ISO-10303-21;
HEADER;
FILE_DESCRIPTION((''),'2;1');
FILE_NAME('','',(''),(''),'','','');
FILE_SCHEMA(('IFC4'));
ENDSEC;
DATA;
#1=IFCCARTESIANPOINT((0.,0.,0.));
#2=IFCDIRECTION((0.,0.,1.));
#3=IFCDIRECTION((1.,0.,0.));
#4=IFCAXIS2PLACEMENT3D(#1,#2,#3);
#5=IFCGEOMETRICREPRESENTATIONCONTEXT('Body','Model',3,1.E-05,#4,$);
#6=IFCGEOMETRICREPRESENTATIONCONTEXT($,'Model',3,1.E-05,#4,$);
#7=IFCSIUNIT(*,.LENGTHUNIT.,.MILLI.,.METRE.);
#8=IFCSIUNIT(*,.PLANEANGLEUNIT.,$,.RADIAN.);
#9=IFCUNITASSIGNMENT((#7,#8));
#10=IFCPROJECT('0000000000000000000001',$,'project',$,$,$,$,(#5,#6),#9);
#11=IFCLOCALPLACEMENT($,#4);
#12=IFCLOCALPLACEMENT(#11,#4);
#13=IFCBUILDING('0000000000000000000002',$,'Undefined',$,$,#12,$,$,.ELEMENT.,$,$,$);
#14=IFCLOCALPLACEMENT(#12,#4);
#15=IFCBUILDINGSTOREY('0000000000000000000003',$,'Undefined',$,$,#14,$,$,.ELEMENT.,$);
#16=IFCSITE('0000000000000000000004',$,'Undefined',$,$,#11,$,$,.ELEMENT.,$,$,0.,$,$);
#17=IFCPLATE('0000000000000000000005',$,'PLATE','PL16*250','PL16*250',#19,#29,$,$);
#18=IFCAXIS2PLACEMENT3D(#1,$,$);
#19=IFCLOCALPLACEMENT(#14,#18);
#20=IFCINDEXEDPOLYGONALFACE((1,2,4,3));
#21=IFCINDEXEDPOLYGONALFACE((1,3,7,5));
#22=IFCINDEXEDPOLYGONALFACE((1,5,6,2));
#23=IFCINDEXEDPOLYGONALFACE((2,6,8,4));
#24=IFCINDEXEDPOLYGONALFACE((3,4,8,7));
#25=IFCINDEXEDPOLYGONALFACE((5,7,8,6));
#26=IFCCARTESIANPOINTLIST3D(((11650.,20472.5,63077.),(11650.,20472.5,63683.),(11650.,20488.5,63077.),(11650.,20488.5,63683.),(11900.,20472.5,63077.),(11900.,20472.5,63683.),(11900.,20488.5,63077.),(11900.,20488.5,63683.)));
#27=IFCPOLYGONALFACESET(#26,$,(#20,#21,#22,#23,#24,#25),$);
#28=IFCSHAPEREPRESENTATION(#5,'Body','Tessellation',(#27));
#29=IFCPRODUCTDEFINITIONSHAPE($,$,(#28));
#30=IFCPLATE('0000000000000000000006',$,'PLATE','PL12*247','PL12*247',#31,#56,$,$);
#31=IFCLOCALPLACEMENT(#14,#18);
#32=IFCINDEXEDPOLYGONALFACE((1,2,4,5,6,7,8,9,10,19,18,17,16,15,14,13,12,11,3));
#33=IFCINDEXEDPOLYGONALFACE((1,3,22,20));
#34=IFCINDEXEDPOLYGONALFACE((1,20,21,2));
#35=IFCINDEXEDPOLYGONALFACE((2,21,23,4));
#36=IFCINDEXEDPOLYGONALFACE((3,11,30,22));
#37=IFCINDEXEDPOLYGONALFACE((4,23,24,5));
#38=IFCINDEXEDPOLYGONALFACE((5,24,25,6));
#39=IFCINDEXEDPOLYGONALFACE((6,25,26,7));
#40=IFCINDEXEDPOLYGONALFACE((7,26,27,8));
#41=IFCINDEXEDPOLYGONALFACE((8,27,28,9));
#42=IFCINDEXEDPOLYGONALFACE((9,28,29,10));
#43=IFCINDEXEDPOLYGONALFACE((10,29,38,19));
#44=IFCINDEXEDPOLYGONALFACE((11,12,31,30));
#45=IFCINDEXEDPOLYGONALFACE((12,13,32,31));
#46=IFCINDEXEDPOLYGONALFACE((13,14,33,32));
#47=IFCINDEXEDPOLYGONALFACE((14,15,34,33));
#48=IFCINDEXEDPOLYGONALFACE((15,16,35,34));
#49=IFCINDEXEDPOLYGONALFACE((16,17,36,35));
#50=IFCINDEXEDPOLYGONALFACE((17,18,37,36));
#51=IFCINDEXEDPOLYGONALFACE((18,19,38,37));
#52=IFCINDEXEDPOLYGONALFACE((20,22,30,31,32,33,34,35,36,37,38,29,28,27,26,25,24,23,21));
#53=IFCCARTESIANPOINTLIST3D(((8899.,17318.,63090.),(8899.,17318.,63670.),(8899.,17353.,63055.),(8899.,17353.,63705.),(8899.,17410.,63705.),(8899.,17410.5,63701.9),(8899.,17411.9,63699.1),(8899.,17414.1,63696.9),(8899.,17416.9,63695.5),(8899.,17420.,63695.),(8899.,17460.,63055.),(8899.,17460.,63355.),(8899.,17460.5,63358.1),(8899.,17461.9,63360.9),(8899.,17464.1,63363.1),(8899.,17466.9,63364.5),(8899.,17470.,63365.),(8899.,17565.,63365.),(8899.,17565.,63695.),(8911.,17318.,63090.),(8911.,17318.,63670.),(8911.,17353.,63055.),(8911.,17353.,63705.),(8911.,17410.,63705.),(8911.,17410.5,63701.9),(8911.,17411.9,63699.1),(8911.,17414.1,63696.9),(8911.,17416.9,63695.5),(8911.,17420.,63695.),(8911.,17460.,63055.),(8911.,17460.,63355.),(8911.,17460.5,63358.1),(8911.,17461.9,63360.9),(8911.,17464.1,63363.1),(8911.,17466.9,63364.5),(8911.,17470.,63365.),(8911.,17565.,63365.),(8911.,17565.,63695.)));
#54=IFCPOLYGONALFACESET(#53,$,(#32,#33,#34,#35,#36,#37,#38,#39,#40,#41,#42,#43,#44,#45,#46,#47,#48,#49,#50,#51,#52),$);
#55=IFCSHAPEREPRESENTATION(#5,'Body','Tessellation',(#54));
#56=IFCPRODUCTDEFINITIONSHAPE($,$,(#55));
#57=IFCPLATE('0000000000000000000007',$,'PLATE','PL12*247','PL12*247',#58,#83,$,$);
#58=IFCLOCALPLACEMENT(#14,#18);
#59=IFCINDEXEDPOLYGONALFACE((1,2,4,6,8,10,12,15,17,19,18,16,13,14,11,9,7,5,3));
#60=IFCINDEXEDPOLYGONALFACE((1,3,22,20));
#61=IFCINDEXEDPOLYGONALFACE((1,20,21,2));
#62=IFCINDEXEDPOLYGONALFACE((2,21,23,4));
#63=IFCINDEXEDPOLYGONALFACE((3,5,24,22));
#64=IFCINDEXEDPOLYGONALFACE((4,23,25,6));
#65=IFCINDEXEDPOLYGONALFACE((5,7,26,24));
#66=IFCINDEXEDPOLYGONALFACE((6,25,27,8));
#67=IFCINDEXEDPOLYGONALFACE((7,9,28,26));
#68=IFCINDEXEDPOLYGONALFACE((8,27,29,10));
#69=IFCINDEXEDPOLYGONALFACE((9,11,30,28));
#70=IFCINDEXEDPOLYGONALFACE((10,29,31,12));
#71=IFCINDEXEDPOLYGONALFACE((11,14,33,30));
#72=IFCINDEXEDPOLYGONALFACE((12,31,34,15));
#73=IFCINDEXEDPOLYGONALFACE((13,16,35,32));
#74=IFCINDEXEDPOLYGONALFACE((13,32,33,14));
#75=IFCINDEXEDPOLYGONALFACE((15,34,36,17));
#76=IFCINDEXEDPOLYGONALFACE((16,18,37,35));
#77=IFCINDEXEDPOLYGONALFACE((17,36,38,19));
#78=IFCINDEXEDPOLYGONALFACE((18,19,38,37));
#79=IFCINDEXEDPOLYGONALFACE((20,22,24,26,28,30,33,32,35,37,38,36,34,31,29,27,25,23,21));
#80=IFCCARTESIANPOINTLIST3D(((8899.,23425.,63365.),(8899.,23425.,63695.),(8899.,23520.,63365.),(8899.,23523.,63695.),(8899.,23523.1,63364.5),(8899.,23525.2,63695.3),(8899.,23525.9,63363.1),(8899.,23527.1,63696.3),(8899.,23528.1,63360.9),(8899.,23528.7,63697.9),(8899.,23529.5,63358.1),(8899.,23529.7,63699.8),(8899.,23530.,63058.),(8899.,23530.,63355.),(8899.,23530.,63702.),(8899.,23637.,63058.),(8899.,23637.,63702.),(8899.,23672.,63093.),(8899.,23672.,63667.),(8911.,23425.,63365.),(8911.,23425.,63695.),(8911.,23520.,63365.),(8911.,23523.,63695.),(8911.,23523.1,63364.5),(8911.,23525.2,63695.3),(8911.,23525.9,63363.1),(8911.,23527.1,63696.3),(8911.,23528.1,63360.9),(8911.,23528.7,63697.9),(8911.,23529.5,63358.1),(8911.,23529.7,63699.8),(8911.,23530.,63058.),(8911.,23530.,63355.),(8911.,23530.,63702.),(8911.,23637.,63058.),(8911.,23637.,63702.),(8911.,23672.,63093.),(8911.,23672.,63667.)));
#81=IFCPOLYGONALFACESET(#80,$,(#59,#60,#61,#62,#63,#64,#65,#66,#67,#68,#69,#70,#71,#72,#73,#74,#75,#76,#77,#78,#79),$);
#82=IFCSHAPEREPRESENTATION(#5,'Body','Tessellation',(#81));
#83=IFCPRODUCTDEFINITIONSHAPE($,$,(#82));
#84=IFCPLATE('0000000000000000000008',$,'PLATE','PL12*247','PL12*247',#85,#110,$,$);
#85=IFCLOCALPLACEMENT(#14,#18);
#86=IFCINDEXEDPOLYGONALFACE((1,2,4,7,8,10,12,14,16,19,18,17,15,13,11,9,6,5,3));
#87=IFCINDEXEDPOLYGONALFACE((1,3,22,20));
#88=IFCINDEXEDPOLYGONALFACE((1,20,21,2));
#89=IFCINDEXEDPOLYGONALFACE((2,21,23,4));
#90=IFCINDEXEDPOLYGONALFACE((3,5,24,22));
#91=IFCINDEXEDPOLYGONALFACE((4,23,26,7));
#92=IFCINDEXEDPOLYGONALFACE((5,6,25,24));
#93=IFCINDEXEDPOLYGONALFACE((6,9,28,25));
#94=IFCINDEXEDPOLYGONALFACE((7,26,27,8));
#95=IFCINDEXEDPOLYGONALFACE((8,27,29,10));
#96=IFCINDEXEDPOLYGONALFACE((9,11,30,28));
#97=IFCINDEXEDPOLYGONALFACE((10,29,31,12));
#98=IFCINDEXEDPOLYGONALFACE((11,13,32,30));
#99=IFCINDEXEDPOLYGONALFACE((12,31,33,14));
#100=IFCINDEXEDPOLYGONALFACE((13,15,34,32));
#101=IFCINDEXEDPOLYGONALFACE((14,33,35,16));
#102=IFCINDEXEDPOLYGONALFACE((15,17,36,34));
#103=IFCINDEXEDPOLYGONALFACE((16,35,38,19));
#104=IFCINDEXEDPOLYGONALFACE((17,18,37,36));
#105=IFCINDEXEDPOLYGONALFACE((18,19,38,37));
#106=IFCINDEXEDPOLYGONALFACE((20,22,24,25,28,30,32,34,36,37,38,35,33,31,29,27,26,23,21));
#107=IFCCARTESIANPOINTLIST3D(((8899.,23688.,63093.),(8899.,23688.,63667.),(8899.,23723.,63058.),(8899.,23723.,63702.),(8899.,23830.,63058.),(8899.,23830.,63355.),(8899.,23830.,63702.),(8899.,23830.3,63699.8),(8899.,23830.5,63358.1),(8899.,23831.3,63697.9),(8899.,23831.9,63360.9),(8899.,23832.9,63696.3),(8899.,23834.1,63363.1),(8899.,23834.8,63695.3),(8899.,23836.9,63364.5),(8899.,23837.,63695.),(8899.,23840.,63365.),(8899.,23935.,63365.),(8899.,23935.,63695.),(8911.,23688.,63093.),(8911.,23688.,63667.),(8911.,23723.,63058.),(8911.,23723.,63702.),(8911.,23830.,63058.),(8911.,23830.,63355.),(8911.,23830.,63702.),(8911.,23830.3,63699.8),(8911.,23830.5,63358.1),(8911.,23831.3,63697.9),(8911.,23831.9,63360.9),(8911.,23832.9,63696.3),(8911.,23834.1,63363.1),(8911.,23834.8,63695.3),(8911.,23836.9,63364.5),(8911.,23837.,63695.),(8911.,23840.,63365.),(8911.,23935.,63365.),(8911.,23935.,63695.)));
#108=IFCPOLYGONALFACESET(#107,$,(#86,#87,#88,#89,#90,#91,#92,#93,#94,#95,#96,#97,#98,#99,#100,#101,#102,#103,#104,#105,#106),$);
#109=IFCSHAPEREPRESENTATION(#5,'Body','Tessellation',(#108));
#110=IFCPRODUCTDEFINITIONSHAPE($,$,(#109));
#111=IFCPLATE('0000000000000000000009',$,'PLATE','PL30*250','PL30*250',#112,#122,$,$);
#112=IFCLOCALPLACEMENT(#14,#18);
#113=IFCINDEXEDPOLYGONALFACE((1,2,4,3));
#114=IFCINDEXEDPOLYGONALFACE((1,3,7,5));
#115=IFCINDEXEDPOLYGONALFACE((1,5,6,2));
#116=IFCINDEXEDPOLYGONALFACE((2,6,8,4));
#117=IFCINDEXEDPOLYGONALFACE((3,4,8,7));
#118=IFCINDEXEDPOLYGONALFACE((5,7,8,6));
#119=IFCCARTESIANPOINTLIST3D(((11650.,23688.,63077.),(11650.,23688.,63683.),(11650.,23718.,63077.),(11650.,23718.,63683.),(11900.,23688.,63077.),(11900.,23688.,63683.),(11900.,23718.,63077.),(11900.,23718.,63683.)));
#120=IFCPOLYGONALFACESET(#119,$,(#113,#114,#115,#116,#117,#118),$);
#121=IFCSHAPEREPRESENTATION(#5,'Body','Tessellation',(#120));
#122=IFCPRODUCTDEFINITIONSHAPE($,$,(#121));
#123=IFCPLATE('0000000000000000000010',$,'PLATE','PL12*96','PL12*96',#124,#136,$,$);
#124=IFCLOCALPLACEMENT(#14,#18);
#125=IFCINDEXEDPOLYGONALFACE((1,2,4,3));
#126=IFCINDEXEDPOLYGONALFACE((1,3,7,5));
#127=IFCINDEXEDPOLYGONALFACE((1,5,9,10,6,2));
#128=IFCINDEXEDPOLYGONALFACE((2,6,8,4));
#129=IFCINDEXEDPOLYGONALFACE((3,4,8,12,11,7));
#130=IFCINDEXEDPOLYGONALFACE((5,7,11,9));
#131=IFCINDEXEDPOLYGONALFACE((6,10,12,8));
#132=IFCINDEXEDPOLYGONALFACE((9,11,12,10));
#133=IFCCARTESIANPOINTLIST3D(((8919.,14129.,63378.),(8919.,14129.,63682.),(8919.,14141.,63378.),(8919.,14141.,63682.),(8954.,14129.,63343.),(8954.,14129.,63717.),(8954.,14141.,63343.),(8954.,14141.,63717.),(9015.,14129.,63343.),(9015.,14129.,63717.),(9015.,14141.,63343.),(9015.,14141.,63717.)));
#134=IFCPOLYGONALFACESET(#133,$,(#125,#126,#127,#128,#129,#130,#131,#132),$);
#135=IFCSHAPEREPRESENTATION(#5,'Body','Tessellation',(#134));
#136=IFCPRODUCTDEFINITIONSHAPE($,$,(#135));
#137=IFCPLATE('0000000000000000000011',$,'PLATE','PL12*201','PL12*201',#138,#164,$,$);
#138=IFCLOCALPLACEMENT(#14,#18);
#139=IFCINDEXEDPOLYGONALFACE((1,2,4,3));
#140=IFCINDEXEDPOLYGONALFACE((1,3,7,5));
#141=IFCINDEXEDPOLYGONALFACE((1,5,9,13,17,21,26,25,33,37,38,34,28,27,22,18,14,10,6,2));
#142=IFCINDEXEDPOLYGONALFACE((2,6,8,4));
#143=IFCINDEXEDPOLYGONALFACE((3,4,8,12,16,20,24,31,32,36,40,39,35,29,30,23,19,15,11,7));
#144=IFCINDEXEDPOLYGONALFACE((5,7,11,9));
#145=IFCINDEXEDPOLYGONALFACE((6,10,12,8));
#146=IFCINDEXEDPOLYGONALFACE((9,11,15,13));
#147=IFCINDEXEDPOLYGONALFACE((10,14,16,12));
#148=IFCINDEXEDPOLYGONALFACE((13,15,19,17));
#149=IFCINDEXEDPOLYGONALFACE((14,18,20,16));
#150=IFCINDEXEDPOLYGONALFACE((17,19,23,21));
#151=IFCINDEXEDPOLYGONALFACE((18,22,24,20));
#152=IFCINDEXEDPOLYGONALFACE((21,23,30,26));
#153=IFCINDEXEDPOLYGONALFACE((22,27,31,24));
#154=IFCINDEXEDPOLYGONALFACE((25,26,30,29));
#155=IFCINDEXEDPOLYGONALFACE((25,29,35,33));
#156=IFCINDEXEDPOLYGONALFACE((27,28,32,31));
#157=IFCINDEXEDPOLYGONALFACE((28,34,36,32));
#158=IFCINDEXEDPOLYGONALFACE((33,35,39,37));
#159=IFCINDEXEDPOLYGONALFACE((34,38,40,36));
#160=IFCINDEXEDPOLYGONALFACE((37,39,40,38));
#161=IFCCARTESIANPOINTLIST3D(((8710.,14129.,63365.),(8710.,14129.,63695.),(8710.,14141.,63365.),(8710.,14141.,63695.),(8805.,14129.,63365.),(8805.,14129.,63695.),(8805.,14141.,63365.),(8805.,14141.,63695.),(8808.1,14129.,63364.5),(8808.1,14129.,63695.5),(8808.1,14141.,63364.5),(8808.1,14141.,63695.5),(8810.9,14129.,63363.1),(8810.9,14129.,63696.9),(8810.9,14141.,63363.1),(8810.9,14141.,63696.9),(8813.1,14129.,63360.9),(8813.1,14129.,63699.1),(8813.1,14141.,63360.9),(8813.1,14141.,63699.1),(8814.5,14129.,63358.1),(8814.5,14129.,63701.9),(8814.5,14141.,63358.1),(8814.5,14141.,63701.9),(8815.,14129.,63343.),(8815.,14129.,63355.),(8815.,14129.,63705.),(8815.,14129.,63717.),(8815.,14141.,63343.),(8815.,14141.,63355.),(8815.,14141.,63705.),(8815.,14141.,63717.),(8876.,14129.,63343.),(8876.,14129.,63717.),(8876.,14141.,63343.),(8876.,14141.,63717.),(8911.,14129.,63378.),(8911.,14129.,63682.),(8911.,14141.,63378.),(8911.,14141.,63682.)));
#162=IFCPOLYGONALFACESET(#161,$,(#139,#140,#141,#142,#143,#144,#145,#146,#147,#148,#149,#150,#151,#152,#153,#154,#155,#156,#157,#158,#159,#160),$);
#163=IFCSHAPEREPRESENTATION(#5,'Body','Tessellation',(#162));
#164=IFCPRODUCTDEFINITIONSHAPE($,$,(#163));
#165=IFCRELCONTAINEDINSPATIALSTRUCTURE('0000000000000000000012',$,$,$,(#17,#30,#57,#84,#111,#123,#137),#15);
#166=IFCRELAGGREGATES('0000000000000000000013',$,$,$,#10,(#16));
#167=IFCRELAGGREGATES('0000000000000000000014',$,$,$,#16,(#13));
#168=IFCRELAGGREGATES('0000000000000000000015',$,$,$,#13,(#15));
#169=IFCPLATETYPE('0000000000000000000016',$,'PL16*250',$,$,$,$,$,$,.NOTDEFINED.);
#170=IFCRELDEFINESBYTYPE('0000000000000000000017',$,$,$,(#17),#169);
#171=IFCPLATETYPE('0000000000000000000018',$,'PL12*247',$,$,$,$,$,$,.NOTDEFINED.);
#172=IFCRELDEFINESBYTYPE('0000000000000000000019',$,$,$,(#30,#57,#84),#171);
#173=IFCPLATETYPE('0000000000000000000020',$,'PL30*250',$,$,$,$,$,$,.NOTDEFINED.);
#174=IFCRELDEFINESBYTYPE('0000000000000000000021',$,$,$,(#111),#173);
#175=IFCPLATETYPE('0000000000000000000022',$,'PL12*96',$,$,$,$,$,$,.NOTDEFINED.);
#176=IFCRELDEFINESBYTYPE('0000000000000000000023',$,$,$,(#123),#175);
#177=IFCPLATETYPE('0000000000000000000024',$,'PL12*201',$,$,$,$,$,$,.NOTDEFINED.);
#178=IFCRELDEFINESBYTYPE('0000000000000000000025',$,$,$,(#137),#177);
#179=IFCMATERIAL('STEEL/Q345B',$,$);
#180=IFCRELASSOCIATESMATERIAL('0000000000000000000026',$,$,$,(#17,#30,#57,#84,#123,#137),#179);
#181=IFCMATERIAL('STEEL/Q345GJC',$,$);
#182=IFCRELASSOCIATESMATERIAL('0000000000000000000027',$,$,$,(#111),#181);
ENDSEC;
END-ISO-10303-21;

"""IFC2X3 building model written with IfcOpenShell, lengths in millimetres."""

from ifc_helpers import new_model, si_unit, frame, origin_with_axes, place, context, project, spatial, polyline, outline, extrude, material, type_object, element, save


model = new_model("IFC2X3")

# Units and contexts
model_context_1 = context("Model", 3, precision=1e-05, world=origin_with_axes(), identifier="Body")
model_context_2 = context("Model", 3, precision=1e-05, world=origin_with_axes())
ifc_project = project(units=[si_unit("LENGTHUNIT", "METRE", prefix="MILLI"), si_unit("PLANEANGLEUNIT", "RADIAN")], contexts=[model_context_1, model_context_2])

# Site, building, storey
site_placement = place(None, origin_with_axes())
site = spatial("IfcSite", under=ifc_project, at=site_placement, Name="Undefined", CompositionType="ELEMENT", RefElevation=0.0)
building_placement = place(site_placement, origin_with_axes())
building = spatial("IfcBuilding", under=site, at=building_placement, Name="Undefined", CompositionType="ELEMENT")
storey_placement = place(building_placement, origin_with_axes())
storey = spatial("IfcBuildingStorey", under=building, at=storey_placement, Name="Undefined", CompositionType="ELEMENT")

# Shared definitions
ifc_material_1 = material(Name="STEEL/Q345B")

# Shared definitions
ifc_material_2 = material(Name="STEEL/Q345GJC")

# Plates
plate_type_1 = type_object("IfcPlateType", Name="PL16*250", PredefinedType="NOTDEFINED")
plate_1_placement = place(storey_placement, frame((11650.0, 20480.5, 63683.0), z_axis=(0.0, 1.0, 0.0), x_axis=(1.0, 0.0, 0.0)))
element("IfcPlate", 1, at=plate_1_placement, inside=storey, type_object=plate_type_1, material=ifc_material_1, Name="PLATE", Description="PL16*250", ObjectType="PL16*250", context=model_context_1, shape_type="SweptSolid", body=[
    extrude(outline(polyline([(0.0, 0.0), (250.0, 0.0), (250.0, 606.0), (0.0, 606.0), (0.0, 0.0)])), frame((0.0, 0.0, -8.0), z_axis=(0.0, 0.0, 1.0), x_axis=(1.0, 0.0, 0.0)), (0.0, 0.0, 1.0), 16.0),
])
plate_type_2 = type_object("IfcPlateType", Name="PL12*247", PredefinedType="NOTDEFINED")
for number, where, z_axis, x_axis, name in (
    (2, (8905.0, 17318.0, 63090.0), (1.0, 0.0, 0.0), (0.0, 0.707107, -0.707107), "PLATE"),
):
    element("IfcPlate", number, at=place(storey_placement, frame(where, z_axis=z_axis, x_axis=x_axis)), inside=storey, type_object=plate_type_2, material=ifc_material_1, Name=name, Description="PL12*247", ObjectType="PL12*247", context=model_context_1, shape_type="SweptSolid", body=[
        extrude(outline(polyline([(0.0, 0.0), (49.5, 0.0), (125.2, 75.7), (-87.0, 287.8), (-88.8, 290.3), (-89.8, 293.3), (-89.8, 296.4), (-88.8, 299.4), (-87.0, 301.9), (-19.8, 369.1), (-253.1, 602.5), (-355.7, 499.9), (-358.2, 498.1), (-361.2, 497.1), (-364.3, 497.1), (-367.3, 498.1), (-369.8, 499.9), (-410.1, 459.6), (-410.1, 410.1), (0.0, 0.0)])), frame((0.0, 0.0, -6.0), z_axis=(0.0, 0.0, 1.0), x_axis=(1.0, 0.0, 0.0)), (0.0, 0.0, 1.0), 12.0),
    ])
for number, where, z_axis, x_axis, name in (
    (3, (8905.0, 23672.0, 63093.0), (-1.0, 0.0, 0.0), (0.0, -0.707107, -0.707107), "PLATE"),
    (4, (8905.0, 23688.0, 63093.0), (1.0, 0.0, 0.0), (0.0, 0.707107, -0.707107), "PLATE"),
):
    element("IfcPlate", number, at=place(storey_placement, frame(where, z_axis=z_axis, x_axis=x_axis)), inside=storey, type_object=plate_type_2, material=ifc_material_1, Name=name, Description="PL12*247", ObjectType="PL12*247", context=model_context_1, shape_type="SweptSolid", body=[
        extrude(outline(polyline([(0.0, 0.0), (49.5, 0.0), (125.2, 75.7), (-84.9, 285.7), (-86.7, 288.2), (-87.7, 291.2), (-87.7, 294.3), (-86.7, 297.3), (-84.9, 299.8), (-17.7, 367.0), (-251.0, 600.3), (-320.3, 531.0), (-322.1, 529.7), (-324.2, 529.1), (-326.4, 529.1), (-328.4, 529.7), (-330.2, 531.0), (-405.9, 455.4), (-405.9, 405.9), (0.0, 0.0)])), frame((0.0, 0.0, -6.0), z_axis=(0.0, 0.0, 1.0), x_axis=(1.0, 0.0, 0.0)), (0.0, 0.0, 1.0), 12.0),
    ])
plate_type_3 = type_object("IfcPlateType", Name="PL30*250", PredefinedType="NOTDEFINED")
plate_2_placement = place(storey_placement, frame((11650.0, 23703.0, 63683.0), z_axis=(0.0, 1.0, 0.0), x_axis=(1.0, 0.0, 0.0)))
element("IfcPlate", 5, at=plate_2_placement, inside=storey, type_object=plate_type_3, material=ifc_material_2, Name="PLATE", Description="PL30*250", ObjectType="PL30*250", context=model_context_1, shape_type="SweptSolid", body=[
    extrude(outline(polyline([(0.0, 0.0), (250.0, 0.0), (250.0, 606.0), (0.0, 606.0), (0.0, 0.0)])), frame((0.0, 0.0, -15.0), z_axis=(0.0, 0.0, 1.0), x_axis=(1.0, 0.0, 0.0)), (0.0, 0.0, 1.0), 30.0),
])
plate_type_4 = type_object("IfcPlateType", Name="PL12*96", PredefinedType="NOTDEFINED")
plate_3_placement = place(storey_placement, frame((8919.0, 14135.0, 63343.0), z_axis=(0.0, -1.0, 0.0), x_axis=(1.0, 0.0, 0.0)))
element("IfcPlate", 6, at=plate_3_placement, inside=storey, type_object=plate_type_4, material=ifc_material_1, Name="PLATE", Description="PL12*96", ObjectType="PL12*96", context=model_context_1, shape_type="SweptSolid", body=[
    extrude(outline(polyline([(0.0, 35.0), (35.0, 0.0), (96.0, 0.0), (96.0, 374.0), (35.0, 374.0), (0.0, 339.0), (0.0, 35.0)])), frame((0.0, 0.0, -6.0), z_axis=(0.0, 0.0, 1.0), x_axis=(1.0, 0.0, 0.0)), (0.0, 0.0, 1.0), 12.0),
])
plate_type_5 = type_object("IfcPlateType", Name="PL12*201", PredefinedType="NOTDEFINED")
plate_4_placement = place(storey_placement, frame((8911.0, 14135.0, 63378.0), z_axis=(0.0, 1.0, 0.0), x_axis=(-0.707107, 0.0, -0.707107)))
element("IfcPlate", 7, at=plate_4_placement, inside=storey, type_object=plate_type_5, material=ifc_material_1, Name="PLATE", Description="PL12*201", ObjectType="PL12*201", context=model_context_1, shape_type="SweptSolid", body=[
    extrude(outline(polyline([(0.0, 0.0), (49.5, 0.0), (92.6, 43.1), (84.1, 51.6), (82.3, 54.1), (81.3, 57.1), (81.3, 60.3), (82.3, 63.2), (84.1, 65.8), (151.3, 132.9), (-82.0, 366.3), (-149.2, 299.1), (-151.7, 297.3), (-154.7, 296.3), (-157.8, 296.3), (-160.8, 297.3), (-163.3, 299.1), (-171.8, 307.6), (-215.0, 264.5), (-215.0, 215.0), (0.0, 0.0)])), frame((0.0, 0.0, -6.0), z_axis=(0.0, 0.0, 1.0), x_axis=(1.0, 0.0, 0.0)), (0.0, 0.0, 1.0), 12.0),
])

save(model, "model.ifc")
